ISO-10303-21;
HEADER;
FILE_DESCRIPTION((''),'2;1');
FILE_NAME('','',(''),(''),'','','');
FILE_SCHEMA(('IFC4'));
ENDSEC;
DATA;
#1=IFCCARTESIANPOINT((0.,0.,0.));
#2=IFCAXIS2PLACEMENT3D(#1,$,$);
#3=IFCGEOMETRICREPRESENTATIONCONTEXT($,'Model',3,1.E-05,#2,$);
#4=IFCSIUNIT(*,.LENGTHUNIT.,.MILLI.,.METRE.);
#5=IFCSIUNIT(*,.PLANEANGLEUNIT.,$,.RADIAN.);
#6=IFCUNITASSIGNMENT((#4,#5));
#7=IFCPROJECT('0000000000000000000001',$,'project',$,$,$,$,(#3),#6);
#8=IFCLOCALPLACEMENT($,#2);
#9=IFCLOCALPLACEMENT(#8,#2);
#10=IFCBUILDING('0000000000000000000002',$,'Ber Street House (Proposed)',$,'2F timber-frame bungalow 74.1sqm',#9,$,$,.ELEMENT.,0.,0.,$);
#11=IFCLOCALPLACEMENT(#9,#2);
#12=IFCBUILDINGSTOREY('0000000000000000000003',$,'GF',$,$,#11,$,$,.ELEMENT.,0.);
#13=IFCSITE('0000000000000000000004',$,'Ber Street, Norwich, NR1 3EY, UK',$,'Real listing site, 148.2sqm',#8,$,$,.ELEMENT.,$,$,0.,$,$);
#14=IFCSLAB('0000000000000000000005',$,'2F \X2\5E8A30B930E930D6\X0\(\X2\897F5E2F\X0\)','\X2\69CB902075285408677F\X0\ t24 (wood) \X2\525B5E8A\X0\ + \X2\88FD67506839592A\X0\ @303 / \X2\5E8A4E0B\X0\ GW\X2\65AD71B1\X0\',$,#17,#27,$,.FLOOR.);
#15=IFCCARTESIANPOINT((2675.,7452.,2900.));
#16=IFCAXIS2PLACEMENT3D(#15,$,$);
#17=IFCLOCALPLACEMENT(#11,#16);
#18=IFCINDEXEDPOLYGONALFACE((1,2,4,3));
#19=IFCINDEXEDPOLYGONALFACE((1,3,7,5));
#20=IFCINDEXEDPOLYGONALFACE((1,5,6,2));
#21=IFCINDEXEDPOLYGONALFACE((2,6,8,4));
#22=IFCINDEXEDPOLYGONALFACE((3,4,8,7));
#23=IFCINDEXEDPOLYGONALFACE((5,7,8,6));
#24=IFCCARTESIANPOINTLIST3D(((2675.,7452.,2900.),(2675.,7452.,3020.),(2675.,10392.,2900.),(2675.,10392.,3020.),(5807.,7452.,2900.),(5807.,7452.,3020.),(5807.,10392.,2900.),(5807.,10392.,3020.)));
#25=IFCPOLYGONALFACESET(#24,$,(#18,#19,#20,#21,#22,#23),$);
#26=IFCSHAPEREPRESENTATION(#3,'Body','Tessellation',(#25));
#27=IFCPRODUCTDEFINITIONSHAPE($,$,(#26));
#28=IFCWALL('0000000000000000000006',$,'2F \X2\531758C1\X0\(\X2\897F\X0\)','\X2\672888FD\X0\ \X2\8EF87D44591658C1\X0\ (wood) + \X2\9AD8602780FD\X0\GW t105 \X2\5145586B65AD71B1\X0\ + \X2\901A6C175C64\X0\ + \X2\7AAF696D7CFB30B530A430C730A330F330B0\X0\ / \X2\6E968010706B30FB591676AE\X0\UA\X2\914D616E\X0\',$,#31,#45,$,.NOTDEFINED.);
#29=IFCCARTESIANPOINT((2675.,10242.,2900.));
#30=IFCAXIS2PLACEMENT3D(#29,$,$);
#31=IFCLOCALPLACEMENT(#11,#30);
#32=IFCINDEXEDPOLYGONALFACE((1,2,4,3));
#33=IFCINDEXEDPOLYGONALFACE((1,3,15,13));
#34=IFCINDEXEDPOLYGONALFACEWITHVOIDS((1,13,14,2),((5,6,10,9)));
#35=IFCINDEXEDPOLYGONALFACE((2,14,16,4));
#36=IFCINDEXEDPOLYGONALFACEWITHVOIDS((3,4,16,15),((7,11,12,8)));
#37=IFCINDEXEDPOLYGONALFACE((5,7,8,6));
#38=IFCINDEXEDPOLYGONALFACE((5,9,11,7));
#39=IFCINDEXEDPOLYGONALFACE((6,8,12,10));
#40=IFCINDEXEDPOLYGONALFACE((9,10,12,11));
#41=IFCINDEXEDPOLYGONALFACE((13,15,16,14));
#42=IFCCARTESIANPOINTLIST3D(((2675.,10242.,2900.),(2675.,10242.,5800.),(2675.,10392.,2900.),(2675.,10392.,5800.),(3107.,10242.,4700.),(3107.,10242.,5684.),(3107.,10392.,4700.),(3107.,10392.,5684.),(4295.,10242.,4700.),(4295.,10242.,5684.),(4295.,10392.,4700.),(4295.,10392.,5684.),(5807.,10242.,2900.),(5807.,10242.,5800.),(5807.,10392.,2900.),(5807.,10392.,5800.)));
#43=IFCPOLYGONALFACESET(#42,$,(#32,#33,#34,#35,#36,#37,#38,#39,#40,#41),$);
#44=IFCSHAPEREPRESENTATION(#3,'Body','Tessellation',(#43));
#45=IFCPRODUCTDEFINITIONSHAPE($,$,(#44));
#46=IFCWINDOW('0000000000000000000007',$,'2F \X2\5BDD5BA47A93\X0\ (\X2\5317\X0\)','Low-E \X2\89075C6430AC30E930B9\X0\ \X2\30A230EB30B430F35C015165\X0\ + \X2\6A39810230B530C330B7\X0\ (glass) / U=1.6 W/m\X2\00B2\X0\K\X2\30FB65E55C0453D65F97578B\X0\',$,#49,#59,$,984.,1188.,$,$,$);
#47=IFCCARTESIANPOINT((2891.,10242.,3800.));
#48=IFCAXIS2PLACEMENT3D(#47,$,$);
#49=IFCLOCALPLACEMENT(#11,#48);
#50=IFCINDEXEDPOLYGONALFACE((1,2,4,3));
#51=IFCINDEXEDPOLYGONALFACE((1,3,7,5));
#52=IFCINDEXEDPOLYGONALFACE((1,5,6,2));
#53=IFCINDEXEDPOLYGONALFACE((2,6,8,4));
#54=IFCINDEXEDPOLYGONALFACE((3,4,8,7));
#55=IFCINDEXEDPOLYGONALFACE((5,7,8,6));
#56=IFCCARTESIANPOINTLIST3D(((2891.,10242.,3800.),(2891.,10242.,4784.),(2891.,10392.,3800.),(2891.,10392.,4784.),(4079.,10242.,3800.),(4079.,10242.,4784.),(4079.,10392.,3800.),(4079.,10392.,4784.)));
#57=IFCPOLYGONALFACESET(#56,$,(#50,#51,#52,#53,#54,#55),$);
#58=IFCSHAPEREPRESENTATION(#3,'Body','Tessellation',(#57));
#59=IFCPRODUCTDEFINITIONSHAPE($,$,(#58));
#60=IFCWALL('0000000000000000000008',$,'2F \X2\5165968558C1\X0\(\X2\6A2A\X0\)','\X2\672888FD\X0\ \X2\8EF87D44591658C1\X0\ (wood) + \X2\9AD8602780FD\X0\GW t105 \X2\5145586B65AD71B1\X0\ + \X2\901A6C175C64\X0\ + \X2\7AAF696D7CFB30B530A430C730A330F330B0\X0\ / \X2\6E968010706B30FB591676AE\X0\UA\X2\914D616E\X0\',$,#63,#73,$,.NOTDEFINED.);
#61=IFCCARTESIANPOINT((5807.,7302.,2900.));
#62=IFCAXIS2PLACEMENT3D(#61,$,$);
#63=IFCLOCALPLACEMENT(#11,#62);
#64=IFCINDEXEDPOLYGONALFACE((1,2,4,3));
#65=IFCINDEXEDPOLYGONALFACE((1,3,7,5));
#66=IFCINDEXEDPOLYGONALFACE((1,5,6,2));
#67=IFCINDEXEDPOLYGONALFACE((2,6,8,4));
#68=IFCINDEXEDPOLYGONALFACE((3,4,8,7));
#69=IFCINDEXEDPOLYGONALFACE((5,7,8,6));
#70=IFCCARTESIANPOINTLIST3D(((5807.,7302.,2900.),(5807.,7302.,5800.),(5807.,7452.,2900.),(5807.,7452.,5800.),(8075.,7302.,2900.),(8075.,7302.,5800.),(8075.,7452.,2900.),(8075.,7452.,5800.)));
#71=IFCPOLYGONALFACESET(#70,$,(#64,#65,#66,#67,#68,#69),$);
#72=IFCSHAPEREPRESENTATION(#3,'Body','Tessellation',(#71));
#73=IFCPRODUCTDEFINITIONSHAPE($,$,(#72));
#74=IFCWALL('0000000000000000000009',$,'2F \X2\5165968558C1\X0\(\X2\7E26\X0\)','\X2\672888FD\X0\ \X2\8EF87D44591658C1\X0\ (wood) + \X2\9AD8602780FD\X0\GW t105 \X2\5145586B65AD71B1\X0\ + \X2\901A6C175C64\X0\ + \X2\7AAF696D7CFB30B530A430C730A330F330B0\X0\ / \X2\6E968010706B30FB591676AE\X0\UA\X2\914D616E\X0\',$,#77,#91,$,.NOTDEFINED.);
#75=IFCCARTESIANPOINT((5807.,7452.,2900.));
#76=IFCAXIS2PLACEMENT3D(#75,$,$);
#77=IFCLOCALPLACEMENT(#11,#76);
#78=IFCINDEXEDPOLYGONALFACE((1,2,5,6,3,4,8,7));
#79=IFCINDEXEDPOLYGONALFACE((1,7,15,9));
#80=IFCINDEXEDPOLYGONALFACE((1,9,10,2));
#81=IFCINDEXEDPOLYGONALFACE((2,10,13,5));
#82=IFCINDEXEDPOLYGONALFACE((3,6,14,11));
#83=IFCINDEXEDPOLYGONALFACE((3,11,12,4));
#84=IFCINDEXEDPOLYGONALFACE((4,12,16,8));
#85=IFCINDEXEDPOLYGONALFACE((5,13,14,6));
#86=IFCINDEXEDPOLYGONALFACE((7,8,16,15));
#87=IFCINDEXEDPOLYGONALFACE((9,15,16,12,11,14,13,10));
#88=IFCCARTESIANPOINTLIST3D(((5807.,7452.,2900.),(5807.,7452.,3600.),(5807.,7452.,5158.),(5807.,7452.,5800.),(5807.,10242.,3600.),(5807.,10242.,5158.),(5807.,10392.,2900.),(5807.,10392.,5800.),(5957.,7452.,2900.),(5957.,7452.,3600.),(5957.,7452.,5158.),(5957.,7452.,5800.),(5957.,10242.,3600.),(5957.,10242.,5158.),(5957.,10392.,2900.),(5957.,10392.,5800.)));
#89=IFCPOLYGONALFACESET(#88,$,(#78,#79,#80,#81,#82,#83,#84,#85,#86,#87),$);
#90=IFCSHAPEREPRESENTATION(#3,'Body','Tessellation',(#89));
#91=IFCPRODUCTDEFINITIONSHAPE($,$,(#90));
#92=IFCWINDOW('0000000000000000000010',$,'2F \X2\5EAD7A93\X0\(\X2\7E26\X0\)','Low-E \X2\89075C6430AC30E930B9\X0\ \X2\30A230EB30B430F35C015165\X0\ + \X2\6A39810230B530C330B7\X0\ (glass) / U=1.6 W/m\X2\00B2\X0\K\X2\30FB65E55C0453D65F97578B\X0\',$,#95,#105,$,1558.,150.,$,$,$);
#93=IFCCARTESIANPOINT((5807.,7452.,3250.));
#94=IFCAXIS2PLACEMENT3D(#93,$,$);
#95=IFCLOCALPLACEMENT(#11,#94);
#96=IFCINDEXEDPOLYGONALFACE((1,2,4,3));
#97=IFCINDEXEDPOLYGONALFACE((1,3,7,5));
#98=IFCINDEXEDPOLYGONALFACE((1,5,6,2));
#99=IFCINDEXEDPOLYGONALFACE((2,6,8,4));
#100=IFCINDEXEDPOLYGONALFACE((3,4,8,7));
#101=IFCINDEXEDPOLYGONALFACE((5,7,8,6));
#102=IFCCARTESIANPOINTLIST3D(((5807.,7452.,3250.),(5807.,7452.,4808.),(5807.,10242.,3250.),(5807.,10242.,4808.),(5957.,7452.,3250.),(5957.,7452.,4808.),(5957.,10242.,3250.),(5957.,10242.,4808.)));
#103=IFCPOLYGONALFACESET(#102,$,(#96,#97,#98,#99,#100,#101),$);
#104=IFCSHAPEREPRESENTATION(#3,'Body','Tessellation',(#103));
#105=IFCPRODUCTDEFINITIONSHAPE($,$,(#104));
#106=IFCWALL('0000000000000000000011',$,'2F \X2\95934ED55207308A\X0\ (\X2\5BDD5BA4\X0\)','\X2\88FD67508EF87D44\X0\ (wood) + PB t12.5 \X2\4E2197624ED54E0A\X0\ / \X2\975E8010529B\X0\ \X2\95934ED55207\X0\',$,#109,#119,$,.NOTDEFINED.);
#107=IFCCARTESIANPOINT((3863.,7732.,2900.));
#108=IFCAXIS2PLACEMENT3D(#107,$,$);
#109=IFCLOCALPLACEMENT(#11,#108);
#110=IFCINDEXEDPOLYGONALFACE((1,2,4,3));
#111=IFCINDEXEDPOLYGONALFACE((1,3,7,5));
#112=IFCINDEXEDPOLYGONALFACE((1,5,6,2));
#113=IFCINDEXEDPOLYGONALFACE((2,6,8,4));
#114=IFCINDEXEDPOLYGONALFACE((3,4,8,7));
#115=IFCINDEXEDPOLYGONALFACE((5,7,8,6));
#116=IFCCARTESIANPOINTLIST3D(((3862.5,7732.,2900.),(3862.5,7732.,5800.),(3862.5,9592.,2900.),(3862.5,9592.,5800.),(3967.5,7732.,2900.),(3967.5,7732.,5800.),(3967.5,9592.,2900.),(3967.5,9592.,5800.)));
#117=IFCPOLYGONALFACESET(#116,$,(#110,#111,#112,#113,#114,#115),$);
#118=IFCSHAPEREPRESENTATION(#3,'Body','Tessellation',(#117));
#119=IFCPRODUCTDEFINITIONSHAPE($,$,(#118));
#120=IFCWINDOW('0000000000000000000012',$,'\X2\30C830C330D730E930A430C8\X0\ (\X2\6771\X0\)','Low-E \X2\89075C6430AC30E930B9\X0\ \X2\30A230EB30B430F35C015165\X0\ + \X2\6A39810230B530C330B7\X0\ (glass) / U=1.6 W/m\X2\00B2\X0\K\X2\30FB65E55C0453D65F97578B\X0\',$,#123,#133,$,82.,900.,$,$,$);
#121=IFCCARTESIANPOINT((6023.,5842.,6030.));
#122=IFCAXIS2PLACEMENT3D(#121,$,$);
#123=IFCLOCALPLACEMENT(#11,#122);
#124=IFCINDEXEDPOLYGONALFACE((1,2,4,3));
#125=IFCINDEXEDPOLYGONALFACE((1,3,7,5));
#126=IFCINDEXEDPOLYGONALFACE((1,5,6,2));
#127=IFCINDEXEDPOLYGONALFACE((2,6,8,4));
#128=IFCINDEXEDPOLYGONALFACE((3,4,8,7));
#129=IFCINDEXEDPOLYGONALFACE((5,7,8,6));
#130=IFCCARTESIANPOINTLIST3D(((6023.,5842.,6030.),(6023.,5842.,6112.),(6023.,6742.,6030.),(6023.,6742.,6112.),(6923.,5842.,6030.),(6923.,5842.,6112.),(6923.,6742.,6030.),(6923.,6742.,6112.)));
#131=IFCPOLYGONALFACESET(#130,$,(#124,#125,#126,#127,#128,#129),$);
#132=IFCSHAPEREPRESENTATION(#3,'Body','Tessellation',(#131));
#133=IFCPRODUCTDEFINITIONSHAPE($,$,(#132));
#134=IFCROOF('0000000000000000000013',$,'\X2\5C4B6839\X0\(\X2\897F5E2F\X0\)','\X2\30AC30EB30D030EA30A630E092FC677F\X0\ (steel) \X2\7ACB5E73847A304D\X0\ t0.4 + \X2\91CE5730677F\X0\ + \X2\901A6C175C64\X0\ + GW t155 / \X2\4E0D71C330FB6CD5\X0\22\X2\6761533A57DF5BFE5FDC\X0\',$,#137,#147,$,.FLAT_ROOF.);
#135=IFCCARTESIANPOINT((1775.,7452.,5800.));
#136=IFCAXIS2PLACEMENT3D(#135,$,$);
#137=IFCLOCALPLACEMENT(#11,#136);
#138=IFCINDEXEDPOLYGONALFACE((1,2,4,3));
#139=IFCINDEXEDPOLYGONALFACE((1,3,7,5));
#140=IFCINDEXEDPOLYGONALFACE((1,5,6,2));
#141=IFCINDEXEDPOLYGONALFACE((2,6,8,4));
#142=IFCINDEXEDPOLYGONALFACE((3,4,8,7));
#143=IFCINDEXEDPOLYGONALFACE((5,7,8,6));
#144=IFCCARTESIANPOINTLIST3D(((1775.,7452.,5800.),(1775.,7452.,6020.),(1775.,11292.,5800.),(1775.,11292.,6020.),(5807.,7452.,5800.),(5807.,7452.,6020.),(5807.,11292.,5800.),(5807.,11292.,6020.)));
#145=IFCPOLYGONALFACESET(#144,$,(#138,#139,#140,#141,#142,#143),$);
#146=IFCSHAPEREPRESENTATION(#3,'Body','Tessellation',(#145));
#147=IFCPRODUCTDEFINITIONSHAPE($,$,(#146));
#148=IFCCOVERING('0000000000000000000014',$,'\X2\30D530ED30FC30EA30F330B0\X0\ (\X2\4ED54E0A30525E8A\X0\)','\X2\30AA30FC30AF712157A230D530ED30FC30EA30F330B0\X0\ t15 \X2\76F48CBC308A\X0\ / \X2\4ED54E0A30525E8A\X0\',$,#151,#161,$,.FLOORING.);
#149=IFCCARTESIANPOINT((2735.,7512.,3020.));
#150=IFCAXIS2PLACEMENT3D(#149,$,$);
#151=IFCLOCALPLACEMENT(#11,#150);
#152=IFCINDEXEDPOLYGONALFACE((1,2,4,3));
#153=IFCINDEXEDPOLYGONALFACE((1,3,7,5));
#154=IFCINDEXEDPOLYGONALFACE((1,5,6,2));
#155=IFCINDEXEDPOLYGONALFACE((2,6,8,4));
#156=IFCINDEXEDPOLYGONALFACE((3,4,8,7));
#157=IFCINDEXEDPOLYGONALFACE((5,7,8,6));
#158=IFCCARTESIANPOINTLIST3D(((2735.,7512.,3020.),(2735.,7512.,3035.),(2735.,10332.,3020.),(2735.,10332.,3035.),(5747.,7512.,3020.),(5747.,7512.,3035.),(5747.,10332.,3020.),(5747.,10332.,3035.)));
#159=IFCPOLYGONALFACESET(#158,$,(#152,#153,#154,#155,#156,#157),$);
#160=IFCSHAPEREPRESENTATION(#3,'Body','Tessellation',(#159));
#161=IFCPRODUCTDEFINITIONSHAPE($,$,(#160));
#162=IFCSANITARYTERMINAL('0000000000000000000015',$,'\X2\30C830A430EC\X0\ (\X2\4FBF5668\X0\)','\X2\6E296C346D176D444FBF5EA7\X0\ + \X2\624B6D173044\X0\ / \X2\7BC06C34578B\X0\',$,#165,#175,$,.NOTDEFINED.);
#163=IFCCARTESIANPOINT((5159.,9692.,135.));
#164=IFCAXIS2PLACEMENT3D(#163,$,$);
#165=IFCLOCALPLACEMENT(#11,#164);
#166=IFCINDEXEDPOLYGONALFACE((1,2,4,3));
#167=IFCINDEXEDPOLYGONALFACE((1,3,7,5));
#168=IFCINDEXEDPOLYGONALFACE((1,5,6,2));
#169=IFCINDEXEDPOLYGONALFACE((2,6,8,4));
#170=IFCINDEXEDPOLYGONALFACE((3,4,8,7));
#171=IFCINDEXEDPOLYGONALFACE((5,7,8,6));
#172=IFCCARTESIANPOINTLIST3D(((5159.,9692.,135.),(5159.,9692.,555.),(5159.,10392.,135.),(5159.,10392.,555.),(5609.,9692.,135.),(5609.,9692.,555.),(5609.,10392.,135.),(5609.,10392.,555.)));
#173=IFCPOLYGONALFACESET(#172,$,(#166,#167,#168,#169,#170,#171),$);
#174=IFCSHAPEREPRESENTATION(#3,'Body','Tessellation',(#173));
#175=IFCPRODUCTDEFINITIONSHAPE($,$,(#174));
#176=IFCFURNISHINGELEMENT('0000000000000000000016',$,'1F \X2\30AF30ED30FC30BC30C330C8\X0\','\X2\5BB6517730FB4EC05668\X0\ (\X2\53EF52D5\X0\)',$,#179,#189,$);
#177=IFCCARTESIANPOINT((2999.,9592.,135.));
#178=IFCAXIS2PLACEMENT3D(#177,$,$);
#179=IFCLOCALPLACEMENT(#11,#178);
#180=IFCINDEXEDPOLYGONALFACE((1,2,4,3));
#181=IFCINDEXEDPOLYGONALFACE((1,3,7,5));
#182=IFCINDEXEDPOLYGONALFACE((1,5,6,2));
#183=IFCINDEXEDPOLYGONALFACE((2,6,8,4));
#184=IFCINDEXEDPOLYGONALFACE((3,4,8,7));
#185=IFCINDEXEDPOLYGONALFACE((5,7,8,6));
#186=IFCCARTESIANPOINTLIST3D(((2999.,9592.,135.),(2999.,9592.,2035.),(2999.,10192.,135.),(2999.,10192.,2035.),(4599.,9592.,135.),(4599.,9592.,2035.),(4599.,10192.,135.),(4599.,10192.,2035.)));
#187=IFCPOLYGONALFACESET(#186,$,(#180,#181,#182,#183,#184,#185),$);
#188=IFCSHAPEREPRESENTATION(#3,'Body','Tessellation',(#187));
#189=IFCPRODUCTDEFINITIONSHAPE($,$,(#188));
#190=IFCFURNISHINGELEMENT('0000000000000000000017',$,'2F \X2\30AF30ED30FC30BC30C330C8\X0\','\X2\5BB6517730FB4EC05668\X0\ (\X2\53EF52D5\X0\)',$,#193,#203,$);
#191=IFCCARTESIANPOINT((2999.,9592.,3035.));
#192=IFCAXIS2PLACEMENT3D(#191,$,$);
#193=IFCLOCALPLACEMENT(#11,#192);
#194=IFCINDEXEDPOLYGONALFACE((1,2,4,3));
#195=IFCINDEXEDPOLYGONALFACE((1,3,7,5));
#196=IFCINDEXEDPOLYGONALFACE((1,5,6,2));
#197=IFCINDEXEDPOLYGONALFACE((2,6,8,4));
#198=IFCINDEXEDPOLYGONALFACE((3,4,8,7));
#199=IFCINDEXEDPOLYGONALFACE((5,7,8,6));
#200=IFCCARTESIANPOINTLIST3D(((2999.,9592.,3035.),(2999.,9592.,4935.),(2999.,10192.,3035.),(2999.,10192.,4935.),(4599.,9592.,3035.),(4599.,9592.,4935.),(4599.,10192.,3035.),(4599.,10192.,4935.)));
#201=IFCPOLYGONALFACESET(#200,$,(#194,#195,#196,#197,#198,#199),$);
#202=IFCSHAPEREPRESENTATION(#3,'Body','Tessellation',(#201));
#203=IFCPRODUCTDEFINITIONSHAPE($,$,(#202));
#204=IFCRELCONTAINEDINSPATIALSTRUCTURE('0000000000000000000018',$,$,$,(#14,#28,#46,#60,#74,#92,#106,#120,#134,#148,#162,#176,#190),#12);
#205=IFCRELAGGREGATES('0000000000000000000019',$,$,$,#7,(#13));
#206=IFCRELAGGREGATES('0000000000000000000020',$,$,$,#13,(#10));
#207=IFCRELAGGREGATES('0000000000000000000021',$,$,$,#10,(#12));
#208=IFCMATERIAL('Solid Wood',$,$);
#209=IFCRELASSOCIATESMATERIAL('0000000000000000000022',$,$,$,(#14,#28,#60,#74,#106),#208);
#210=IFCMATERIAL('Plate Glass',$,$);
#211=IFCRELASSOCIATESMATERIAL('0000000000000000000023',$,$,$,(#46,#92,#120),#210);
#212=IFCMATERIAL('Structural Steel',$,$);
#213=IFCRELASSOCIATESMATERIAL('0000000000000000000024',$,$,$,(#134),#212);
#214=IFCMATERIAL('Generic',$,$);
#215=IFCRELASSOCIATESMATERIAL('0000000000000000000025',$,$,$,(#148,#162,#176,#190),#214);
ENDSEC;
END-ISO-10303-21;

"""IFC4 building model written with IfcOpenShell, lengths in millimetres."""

from ifc_helpers import new_model, si_unit, frame, frame_2d, origin, place, context, project, spatial, rectangle, extrude, material, element, fill, save


model = new_model("IFC4")

# Units and contexts
model_context = context("Model", 3, precision=1e-05, world=origin())
ifc_project = project(units=[si_unit("LENGTHUNIT", "METRE", prefix="MILLI"), si_unit("PLANEANGLEUNIT", "RADIAN")], contexts=[model_context])

# Site, building, storey
site_placement = place(None, origin())
site = spatial("IfcSite", under=ifc_project, at=site_placement, Name="Ber Street, Norwich, NR1 3EY, UK", ObjectType="Real listing site, 148.2sqm", CompositionType="ELEMENT", RefElevation=0.0)
building_placement = place(site_placement, origin())
building = spatial("IfcBuilding", under=site, at=building_placement, Name="Ber Street House (Proposed)", ObjectType="2F timber-frame bungalow 74.1sqm", CompositionType="ELEMENT", ElevationOfRefHeight=0.0, ElevationOfTerrain=0.0)
storey_placement = place(building_placement, origin())
storey = spatial("IfcBuildingStorey", under=building, at=storey_placement, Name="GF", CompositionType="ELEMENT", Elevation=0.0)

# Slab
ifc_material_1 = material(Name="Solid Wood")
slab_placement = place(storey_placement, frame((2675.0, 7452.0, 2900.0)))
element("IfcSlab", 1, at=slab_placement, inside=storey, material=ifc_material_1, Name="2F 床スラブ(西帯)", Description="構造用合板 t24 (wood) 剛床 + 製材根太 @303 / 床下 GW断熱", PredefinedType="FLOOR", context=model_context, shape_type="SweptSolid", body=[
    extrude(rectangle(XDim=3132.0, YDim=2940.0, at=frame_2d((1566.0, 1470.0))), frame((2675.0, 7452.0, 2900.0)), (0.0, 0.0, 1.0), 120.0),
])

# Wall, opening, window
wall_1_placement = place(storey_placement, frame((2675.0, 10242.0, 2900.0)))
wall_1 = element("IfcWall", 2, at=wall_1_placement, inside=storey, material=ifc_material_1, Name="2F 北壁(西)", Description="木製 軸組外壁 (wood) + 高性能GW t105 充填断熱 + 通気層 + 窯業系サイディング / 準耐火・外皮UA配慮", PredefinedType="NOTDEFINED", context=model_context, shape_type="SweptSolid", body=[
    extrude(rectangle(XDim=3132.0, YDim=150.0, at=frame_2d((1566.0, 75.0))), frame((2675.0, 10242.0, 2900.0)), (0.0, 0.0, 1.0), 2900.0),
])
opening_1_placement = place(storey_placement, frame((2891.0, 10242.0, 3800.0)))
opening_1 = element("IfcOpeningElement", 3, at=opening_1_placement, cuts=wall_1, PredefinedType="NOTDEFINED", context=model_context, shape_type="SweptSolid", body=[
    extrude(rectangle(XDim=1188.0, YDim=150.0, at=frame_2d((594.0, 75.0))), frame((2891.0, 10242.0, 3800.0)), (0.0, 0.0, 1.0), 984.0),
])
ifc_material_2 = material(Name="Plate Glass")
window_1_placement = place(storey_placement, frame((2891.0, 10242.0, 3800.0)))
window_1 = element("IfcWindow", 4, at=window_1_placement, inside=storey, material=ifc_material_2, Name="2F 寝室窓 (北)", Description="Low-E 複層ガラス アルゴン封入 + 樹脂サッシ (glass) / U=1.6 W/m²K・日射取得型", OverallHeight=984.0, OverallWidth=1188.0, context=model_context, shape_type="SweptSolid", body=[
    extrude(rectangle(XDim=1188.0, YDim=150.0, at=frame_2d((594.0, 75.0))), frame((2891.0, 10242.0, 3800.0)), (0.0, 0.0, 1.0), 984.0),
])
fill(opening_1, window_1)

# Wall
wall_2_placement = place(storey_placement, frame((5807.0, 7302.0, 2900.0)))
element("IfcWall", 5, at=wall_2_placement, inside=storey, material=ifc_material_1, Name="2F 入隅壁(横)", Description="木製 軸組外壁 (wood) + 高性能GW t105 充填断熱 + 通気層 + 窯業系サイディング / 準耐火・外皮UA配慮", PredefinedType="NOTDEFINED", context=model_context, shape_type="SweptSolid", body=[
    extrude(rectangle(XDim=2268.0, YDim=150.0, at=frame_2d((1134.0, 75.0))), frame((5807.0, 7302.0, 2900.0)), (0.0, 0.0, 1.0), 2900.0),
])

# Wall, opening, window
wall_3_placement = place(storey_placement, frame((5807.0, 7452.0, 2900.0)))
wall_3 = element("IfcWall", 6, at=wall_3_placement, inside=storey, material=ifc_material_1, Name="2F 入隅壁(縦)", Description="木製 軸組外壁 (wood) + 高性能GW t105 充填断熱 + 通気層 + 窯業系サイディング / 準耐火・外皮UA配慮", PredefinedType="NOTDEFINED", context=model_context, shape_type="SweptSolid", body=[
    extrude(rectangle(XDim=150.0, YDim=2940.0, at=frame_2d((75.0, 1470.0))), frame((5807.0, 7452.0, 2900.0)), (0.0, 0.0, 1.0), 2900.0),
])
opening_2_placement = place(storey_placement, frame((5807.0, 7452.0, 3250.0)))
opening_2 = element("IfcOpeningElement", 7, at=opening_2_placement, cuts=wall_3, PredefinedType="NOTDEFINED", context=model_context, shape_type="SweptSolid", body=[
    extrude(rectangle(XDim=150.0, YDim=2790.0, at=frame_2d((75.0, 1395.0))), frame((5807.0, 7452.0, 3250.0)), (0.0, 0.0, 1.0), 1558.0),
])
window_2_placement = place(storey_placement, frame((5807.0, 7452.0, 3250.0)))
window_2 = element("IfcWindow", 8, at=window_2_placement, inside=storey, material=ifc_material_2, Name="2F 庭窓(縦)", Description="Low-E 複層ガラス アルゴン封入 + 樹脂サッシ (glass) / U=1.6 W/m²K・日射取得型", OverallHeight=1558.0, OverallWidth=150.0, context=model_context, shape_type="SweptSolid", body=[
    extrude(rectangle(XDim=150.0, YDim=2790.0, at=frame_2d((75.0, 1395.0))), frame((5807.0, 7452.0, 3250.0)), (0.0, 0.0, 1.0), 1558.0),
])
fill(opening_2, window_2)

# Wall
wall_4_placement = place(storey_placement, frame((3863.0, 7732.0, 2900.0)))
element("IfcWall", 9, at=wall_4_placement, inside=storey, material=ifc_material_1, Name="2F 間仕切り (寝室)", Description="製材軸組 (wood) + PB t12.5 両面仕上 / 非耐力 間仕切", PredefinedType="NOTDEFINED", context=model_context, shape_type="SweptSolid", body=[
    extrude(rectangle(XDim=105.0, YDim=1860.0, at=frame_2d((52.0, 930.0))), frame((3863.0, 7732.0, 2900.0)), (0.0, 0.0, 1.0), 2900.0),
])

# Window
window_3_placement = place(storey_placement, frame((6023.0, 5842.0, 6030.0)))
element("IfcWindow", 10, at=window_3_placement, inside=storey, material=ifc_material_2, Name="トップライト (東)", Description="Low-E 複層ガラス アルゴン封入 + 樹脂サッシ (glass) / U=1.6 W/m²K・日射取得型", OverallHeight=82.0, OverallWidth=900.0, context=model_context, shape_type="SweptSolid", body=[
    extrude(rectangle(XDim=900.0, YDim=900.0, at=frame_2d((450.0, 450.0))), frame((6023.0, 5842.0, 6030.0)), (0.0, 0.0, 1.0), 82.0),
])

# Roof
ifc_material_3 = material(Name="Structural Steel")
for number, where, name in (
    (11, (1775.0, 7452.0, 5800.0), "屋根(西帯)"),
):
    element("IfcRoof", number, at=place(storey_placement, frame(where)), inside=storey, material=ifc_material_3, Name=name, Description="ガルバリウム鋼板 (steel) 立平葺き t0.4 + 野地板 + 通気層 + GW t155 / 不燃・法22条区域対応", PredefinedType="FLAT_ROOF", context=model_context, shape_type="SweptSolid", body=[
        extrude(rectangle(XDim=4032.0, YDim=3840.0, at=frame_2d((2016.0, 1920.0))), frame((1775.0, 7452.0, 5800.0)), (0.0, 0.0, 1.0), 220.0),
    ])

# Covering
ifc_material_4 = material(Name="Generic")
covering_placement = place(storey_placement, frame((2735.0, 7512.0, 3020.0)))
element("IfcCovering", 12, at=covering_placement, inside=storey, material=ifc_material_4, Name="フローリング (仕上げ床)", Description="オーク無垢フローリング t15 直貼り / 仕上げ床", PredefinedType="FLOORING", context=model_context, shape_type="SweptSolid", body=[
    extrude(rectangle(XDim=3012.0, YDim=2820.0, at=frame_2d((1506.0, 1410.0))), frame((2735.0, 7512.0, 3020.0)), (0.0, 0.0, 1.0), 15.0),
])

# Sanitary terminal
sanitary_terminal_placement = place(storey_placement, frame((5159.0, 9692.0, 135.0)))
element("IfcSanitaryTerminal", 13, at=sanitary_terminal_placement, inside=storey, material=ifc_material_4, Name="トイレ (便器)", Description="温水洗浄便座 + 手洗い / 節水型", PredefinedType="NOTDEFINED", context=model_context, shape_type="SweptSolid", body=[
    extrude(rectangle(XDim=450.0, YDim=700.0, at=frame_2d((225.0, 350.0))), frame((5159.0, 9692.0, 135.0)), (0.0, 0.0, 1.0), 420.0),
])

# Furnishing elements
furnishing_1_placement = place(storey_placement, frame((2999.0, 9592.0, 135.0)))
element("IfcFurnishingElement", 14, at=furnishing_1_placement, inside=storey, material=ifc_material_4, Name="1F クローゼット", Description="家具・什器 (可動)", context=model_context, shape_type="SweptSolid", body=[
    extrude(rectangle(XDim=1600.0, YDim=600.0, at=frame_2d((800.0, 300.0))), frame((2999.0, 9592.0, 135.0)), (0.0, 0.0, 1.0), 1900.0),
])
furnishing_2_placement = place(storey_placement, frame((2999.0, 9592.0, 3035.0)))
element("IfcFurnishingElement", 15, at=furnishing_2_placement, inside=storey, material=ifc_material_4, Name="2F クローゼット", Description="家具・什器 (可動)", context=model_context, shape_type="SweptSolid", body=[
    extrude(rectangle(XDim=1600.0, YDim=600.0, at=frame_2d((800.0, 300.0))), frame((2999.0, 9592.0, 3035.0)), (0.0, 0.0, 1.0), 1900.0),
])

save(model, "model.ifc")
